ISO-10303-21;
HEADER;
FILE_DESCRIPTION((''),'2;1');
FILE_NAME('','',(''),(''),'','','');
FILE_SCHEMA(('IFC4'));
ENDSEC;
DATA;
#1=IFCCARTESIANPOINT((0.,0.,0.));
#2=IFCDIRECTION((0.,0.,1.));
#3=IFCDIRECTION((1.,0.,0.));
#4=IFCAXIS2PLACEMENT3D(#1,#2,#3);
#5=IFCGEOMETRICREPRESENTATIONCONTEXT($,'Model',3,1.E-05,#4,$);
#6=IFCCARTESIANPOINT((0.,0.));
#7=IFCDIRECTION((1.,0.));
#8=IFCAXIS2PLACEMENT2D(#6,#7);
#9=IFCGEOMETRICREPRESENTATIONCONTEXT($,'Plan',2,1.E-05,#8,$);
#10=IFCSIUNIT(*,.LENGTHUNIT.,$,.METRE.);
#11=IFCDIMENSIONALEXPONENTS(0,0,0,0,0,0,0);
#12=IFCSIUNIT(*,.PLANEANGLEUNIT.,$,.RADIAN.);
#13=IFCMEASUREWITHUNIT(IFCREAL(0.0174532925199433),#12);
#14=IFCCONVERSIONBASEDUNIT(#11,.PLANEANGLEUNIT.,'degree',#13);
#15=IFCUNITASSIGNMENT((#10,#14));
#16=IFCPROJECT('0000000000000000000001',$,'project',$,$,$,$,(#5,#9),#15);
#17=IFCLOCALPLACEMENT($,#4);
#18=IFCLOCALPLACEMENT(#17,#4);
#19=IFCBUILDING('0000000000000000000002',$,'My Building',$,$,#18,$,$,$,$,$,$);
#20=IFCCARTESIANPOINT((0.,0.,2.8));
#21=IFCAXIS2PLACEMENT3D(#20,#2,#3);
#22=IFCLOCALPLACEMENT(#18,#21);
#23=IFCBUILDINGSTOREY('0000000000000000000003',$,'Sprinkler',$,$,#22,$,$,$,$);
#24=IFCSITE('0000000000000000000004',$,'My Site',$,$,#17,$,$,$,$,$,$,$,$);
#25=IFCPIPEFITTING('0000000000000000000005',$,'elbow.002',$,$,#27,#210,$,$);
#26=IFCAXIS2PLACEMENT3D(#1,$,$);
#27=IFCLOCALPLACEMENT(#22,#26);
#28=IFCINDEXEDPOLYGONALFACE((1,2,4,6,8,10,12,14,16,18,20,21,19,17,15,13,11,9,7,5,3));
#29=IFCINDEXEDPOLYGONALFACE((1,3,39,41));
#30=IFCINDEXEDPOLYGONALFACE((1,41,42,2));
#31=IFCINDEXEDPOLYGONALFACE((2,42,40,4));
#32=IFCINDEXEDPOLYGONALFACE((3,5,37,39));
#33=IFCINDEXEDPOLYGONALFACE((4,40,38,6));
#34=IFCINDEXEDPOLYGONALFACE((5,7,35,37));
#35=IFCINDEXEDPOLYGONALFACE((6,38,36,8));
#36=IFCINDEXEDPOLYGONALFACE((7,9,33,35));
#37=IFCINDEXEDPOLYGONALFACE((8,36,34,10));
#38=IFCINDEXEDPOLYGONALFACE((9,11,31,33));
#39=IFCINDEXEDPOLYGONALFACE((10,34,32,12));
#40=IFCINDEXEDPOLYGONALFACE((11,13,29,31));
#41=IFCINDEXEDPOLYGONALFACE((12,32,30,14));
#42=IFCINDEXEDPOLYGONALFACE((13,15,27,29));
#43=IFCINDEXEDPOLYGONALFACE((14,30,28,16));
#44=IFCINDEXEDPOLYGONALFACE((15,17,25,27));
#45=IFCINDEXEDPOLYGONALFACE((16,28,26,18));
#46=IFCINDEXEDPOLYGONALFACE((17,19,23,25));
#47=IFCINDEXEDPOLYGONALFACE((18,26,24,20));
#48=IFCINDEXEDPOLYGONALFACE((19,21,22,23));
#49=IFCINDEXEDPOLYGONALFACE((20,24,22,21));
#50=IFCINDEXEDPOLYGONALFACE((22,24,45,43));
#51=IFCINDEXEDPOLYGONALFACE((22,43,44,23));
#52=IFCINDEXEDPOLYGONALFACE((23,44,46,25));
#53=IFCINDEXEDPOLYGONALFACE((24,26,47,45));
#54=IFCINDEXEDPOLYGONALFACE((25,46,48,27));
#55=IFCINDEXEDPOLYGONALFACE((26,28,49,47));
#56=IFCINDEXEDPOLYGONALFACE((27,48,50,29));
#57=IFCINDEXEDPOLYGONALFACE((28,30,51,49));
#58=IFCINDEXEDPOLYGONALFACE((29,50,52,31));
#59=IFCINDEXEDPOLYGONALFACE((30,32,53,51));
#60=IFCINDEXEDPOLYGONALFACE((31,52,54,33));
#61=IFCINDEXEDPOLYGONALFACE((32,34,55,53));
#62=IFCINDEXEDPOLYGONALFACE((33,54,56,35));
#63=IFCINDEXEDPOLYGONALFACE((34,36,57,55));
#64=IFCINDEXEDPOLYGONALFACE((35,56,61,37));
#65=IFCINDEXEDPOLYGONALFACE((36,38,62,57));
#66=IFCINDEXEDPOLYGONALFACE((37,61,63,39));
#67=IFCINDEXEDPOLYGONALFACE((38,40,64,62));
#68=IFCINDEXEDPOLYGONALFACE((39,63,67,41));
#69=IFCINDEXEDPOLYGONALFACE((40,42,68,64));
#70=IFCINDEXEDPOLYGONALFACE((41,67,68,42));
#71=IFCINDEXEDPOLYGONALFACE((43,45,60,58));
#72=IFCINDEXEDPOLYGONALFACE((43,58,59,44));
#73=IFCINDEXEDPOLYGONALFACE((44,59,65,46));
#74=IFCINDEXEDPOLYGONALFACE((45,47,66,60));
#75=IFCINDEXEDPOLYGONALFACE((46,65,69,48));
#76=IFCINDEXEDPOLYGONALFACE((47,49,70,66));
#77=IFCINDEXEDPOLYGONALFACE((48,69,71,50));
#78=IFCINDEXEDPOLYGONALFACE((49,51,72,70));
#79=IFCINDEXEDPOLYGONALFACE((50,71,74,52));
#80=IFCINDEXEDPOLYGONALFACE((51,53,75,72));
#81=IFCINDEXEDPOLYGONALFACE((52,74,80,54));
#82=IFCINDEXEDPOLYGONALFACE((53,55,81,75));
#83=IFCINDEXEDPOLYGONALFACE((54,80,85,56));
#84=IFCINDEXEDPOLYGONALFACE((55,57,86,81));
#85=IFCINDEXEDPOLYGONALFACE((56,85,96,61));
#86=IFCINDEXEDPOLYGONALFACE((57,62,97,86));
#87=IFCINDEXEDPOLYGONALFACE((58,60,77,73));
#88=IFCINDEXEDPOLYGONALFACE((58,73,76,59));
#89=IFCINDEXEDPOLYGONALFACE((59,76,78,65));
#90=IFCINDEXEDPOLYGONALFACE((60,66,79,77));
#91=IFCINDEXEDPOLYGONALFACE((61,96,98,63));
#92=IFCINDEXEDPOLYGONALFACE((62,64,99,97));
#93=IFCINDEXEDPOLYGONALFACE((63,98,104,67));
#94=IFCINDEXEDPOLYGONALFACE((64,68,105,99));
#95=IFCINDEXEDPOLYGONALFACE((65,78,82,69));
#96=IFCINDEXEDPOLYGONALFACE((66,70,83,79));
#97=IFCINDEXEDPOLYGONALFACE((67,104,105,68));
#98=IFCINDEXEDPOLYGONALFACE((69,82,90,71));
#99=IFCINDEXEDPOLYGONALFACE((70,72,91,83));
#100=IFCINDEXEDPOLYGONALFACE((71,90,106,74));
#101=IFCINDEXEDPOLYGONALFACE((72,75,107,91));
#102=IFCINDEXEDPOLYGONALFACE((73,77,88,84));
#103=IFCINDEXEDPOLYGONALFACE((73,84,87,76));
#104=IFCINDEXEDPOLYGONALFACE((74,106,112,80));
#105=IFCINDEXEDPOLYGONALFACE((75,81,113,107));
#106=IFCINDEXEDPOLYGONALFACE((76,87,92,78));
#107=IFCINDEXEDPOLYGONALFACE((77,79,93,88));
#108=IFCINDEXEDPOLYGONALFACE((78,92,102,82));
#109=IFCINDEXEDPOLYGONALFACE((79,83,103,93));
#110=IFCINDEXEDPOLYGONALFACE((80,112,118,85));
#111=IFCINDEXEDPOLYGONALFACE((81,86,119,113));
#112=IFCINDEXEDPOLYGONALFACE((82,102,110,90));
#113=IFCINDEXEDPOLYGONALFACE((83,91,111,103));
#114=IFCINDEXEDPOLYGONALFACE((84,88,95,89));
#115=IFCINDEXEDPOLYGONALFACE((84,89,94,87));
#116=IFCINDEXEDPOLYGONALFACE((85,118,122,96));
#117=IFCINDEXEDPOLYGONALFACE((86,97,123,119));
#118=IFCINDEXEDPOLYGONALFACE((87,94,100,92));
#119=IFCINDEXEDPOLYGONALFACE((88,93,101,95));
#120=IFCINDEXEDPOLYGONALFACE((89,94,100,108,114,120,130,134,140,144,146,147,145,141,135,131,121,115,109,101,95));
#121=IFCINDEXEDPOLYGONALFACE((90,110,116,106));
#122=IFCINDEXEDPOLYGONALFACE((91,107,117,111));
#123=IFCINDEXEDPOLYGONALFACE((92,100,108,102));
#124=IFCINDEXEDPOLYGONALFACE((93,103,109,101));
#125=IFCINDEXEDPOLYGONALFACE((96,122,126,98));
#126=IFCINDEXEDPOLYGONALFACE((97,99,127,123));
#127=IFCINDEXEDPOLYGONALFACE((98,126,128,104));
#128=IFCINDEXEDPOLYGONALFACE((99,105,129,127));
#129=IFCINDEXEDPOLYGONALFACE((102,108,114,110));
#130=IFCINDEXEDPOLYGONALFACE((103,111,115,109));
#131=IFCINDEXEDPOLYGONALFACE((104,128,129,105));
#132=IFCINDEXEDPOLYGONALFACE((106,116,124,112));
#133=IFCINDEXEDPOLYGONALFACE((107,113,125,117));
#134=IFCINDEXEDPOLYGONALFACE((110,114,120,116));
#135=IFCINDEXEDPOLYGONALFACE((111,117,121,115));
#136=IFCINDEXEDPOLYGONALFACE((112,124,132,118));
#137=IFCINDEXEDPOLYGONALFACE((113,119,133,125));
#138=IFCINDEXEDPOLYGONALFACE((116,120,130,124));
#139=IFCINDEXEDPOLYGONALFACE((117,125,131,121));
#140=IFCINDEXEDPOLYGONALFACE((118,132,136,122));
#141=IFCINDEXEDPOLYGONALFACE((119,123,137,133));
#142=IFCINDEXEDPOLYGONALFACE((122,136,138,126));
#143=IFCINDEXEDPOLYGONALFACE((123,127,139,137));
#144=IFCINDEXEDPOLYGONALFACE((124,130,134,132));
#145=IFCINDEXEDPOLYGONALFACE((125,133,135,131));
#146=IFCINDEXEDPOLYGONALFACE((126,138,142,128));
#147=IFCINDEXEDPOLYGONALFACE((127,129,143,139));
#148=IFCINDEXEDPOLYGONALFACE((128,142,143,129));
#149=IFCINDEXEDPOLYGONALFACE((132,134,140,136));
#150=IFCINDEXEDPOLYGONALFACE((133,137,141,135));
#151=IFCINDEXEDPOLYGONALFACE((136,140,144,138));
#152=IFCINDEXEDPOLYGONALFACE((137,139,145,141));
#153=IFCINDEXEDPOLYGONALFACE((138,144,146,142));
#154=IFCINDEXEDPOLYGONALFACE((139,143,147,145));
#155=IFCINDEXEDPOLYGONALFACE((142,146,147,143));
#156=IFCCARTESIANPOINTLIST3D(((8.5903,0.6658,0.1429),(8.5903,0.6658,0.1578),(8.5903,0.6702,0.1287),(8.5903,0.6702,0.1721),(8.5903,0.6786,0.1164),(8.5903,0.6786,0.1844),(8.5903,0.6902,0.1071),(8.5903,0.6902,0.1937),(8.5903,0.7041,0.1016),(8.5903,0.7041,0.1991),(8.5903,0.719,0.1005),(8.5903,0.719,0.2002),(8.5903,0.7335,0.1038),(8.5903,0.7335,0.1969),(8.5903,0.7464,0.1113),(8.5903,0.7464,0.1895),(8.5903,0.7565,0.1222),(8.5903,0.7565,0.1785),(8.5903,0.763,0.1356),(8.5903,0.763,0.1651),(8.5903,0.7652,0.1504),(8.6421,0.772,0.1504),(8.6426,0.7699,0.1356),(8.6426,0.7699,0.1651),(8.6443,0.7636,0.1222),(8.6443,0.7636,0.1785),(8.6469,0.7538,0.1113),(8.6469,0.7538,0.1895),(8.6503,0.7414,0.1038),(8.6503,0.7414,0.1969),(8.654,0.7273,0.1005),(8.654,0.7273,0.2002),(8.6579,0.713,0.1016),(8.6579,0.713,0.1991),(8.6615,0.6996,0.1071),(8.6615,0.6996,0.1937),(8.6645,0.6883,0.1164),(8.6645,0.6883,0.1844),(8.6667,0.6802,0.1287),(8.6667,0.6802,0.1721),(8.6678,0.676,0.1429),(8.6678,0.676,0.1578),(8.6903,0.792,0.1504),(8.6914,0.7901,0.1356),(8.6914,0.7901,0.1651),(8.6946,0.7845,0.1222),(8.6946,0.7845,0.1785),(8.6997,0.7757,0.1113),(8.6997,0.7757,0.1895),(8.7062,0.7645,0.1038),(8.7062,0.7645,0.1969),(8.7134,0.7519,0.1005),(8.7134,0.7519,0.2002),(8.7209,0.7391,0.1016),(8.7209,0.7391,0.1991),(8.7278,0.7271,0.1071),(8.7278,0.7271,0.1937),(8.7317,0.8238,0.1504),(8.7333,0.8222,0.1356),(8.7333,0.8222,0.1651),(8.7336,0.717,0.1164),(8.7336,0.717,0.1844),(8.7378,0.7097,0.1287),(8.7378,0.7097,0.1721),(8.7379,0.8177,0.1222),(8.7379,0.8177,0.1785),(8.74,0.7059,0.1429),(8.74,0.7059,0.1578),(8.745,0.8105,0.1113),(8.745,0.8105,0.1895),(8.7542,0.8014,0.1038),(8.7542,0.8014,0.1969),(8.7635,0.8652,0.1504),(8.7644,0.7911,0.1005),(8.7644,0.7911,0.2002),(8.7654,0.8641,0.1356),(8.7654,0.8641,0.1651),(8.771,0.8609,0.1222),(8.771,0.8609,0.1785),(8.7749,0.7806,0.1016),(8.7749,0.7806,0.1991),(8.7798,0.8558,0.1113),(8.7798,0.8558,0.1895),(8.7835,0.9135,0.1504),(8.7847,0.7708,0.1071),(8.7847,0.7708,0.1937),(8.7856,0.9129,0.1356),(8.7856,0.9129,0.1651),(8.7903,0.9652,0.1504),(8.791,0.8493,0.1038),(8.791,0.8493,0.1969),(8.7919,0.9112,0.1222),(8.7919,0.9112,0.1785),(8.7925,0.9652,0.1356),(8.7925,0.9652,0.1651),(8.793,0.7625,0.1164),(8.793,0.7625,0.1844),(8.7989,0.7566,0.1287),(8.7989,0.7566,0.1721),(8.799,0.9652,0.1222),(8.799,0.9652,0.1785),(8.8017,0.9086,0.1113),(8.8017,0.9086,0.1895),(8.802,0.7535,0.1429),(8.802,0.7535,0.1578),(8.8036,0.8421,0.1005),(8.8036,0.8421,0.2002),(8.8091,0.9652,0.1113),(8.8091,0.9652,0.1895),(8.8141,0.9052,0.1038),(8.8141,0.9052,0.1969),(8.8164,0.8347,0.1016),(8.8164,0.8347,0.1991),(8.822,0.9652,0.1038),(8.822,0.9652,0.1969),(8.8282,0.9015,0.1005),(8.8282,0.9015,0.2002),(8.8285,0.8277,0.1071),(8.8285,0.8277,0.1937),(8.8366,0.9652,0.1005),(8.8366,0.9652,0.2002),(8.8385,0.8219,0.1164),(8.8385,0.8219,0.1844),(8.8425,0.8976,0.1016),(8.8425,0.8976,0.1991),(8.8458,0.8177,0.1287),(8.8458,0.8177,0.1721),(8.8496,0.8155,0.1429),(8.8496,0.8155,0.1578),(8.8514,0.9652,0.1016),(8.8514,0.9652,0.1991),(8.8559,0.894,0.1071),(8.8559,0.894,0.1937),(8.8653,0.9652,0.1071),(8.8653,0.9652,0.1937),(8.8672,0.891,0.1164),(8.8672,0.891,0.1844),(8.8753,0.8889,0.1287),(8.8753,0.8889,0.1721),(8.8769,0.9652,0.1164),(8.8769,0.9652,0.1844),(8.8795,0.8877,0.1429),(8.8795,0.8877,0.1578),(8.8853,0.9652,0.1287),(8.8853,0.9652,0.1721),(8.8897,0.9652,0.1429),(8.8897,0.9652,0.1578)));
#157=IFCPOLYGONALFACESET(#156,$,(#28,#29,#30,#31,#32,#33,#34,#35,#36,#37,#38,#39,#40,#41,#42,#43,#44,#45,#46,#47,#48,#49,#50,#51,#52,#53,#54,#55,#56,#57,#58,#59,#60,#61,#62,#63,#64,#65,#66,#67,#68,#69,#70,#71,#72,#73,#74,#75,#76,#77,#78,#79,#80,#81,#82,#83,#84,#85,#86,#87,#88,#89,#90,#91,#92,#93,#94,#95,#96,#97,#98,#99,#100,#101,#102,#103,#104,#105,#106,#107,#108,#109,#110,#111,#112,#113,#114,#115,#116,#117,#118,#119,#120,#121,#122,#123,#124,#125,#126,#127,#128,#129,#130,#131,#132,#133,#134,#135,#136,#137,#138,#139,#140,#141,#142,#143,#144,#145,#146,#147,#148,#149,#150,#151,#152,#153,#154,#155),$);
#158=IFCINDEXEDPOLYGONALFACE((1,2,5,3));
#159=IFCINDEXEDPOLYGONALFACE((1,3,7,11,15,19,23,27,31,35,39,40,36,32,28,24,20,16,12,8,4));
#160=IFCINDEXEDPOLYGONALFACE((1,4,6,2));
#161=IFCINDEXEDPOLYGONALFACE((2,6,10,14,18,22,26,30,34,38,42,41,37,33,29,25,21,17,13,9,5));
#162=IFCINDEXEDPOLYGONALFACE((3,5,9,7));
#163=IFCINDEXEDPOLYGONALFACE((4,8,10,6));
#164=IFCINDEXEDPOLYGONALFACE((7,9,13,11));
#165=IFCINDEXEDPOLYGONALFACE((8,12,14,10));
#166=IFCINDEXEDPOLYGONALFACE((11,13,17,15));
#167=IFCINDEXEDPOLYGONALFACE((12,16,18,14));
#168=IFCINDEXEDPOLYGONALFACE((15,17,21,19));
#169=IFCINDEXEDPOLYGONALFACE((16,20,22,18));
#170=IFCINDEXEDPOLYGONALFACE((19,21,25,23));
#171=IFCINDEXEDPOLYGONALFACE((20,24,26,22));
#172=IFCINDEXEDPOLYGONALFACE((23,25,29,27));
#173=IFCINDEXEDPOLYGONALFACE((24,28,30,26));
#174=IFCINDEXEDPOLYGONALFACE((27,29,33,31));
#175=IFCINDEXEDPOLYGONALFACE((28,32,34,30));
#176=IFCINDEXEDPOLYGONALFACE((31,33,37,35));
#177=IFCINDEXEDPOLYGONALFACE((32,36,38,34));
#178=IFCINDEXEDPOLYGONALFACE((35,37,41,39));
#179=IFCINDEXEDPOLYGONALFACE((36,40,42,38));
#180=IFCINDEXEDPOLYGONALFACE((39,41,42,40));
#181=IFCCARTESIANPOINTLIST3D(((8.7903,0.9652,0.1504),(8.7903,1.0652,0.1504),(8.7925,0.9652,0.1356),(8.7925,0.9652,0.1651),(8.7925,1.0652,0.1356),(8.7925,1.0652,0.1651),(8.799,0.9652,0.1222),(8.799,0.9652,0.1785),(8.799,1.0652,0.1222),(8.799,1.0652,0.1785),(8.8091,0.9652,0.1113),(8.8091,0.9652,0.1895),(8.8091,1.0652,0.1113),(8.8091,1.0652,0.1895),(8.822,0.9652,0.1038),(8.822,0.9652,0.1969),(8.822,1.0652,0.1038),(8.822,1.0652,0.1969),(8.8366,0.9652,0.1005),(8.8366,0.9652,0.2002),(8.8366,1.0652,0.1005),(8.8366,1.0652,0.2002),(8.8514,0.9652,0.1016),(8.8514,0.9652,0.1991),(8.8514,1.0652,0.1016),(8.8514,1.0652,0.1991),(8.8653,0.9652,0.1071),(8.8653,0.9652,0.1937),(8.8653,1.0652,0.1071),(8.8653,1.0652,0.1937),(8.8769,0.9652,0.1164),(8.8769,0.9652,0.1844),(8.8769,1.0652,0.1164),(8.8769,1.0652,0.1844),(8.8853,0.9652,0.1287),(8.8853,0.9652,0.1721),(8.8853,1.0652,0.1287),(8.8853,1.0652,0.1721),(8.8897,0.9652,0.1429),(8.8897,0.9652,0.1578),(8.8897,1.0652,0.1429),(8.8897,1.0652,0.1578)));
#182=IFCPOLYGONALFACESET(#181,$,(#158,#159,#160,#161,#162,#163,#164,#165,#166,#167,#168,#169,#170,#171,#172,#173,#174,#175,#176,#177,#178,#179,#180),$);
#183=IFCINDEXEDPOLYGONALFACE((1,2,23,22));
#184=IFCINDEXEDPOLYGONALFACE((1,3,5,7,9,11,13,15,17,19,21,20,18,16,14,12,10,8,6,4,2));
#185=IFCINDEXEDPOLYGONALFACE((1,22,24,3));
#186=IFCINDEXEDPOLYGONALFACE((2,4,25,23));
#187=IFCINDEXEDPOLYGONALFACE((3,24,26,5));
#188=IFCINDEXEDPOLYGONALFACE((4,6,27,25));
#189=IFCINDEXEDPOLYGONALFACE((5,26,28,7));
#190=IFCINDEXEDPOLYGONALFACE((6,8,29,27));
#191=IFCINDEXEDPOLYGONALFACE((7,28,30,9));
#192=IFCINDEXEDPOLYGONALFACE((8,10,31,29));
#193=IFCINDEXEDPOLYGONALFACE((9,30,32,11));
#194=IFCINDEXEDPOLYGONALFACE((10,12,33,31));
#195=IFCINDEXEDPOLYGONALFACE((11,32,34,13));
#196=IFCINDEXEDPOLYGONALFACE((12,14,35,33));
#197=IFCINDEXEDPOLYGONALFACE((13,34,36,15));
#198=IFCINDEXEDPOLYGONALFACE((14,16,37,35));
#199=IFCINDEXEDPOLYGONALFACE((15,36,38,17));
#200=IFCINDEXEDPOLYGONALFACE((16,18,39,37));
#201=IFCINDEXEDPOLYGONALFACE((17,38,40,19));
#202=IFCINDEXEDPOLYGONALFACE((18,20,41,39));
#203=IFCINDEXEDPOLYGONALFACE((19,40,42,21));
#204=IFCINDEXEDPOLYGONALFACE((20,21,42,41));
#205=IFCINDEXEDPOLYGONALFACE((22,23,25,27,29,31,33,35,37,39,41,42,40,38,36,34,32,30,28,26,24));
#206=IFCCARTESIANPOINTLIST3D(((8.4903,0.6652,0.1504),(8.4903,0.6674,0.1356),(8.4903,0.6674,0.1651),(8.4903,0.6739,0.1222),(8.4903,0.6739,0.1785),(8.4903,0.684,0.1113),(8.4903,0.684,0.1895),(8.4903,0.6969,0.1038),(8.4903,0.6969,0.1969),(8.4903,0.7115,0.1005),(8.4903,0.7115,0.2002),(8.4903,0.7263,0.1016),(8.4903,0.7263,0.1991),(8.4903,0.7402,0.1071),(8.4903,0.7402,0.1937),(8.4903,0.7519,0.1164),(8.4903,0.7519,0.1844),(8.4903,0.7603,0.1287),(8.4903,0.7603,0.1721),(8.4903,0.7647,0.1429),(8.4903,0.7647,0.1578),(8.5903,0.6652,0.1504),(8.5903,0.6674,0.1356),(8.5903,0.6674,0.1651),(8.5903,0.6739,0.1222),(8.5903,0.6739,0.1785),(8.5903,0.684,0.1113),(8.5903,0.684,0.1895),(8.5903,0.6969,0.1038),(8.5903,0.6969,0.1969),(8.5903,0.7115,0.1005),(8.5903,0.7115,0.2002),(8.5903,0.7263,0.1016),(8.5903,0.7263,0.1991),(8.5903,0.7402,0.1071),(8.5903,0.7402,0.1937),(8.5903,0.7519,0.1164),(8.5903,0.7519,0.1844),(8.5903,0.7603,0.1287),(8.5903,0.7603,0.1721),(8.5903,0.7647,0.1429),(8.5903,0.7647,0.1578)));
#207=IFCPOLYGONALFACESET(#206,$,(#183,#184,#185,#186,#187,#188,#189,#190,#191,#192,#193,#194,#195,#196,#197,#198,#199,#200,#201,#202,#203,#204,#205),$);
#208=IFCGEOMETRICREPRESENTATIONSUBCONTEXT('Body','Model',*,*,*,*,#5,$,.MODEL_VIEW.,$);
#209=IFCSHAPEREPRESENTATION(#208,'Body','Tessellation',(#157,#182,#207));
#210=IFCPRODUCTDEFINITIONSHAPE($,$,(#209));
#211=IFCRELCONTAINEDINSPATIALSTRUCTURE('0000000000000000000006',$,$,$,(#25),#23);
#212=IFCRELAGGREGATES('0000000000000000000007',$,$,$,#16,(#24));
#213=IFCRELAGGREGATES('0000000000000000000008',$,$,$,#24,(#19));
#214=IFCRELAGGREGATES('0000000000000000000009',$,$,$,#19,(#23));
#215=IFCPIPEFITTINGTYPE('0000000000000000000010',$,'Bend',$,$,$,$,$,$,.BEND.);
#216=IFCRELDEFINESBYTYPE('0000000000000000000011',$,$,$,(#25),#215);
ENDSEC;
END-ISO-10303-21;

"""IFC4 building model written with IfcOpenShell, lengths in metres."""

from ifc_helpers import new_model, entity, si_unit, converted_unit, frame, origin_with_axes, origin_2d_with_axis, place, context, subcontext, project, spatial, circle, extrude, source, transform, mapped, type_object, type_shapes, element, save


model = new_model("IFC4")

# Units and contexts
model_context = context("Model", 3, precision=1e-05, world=origin_with_axes())
plan_context = context("Plan", 2, precision=1e-05, world=origin_2d_with_axis())
body_context = subcontext(model_context, "Body", "Model", "MODEL_VIEW")
ifc_project = project(units=[si_unit("LENGTHUNIT", "METRE"), converted_unit("PLANEANGLEUNIT", "degree", entity("IfcReal", 0.0174532925199433), si_unit("PLANEANGLEUNIT", "RADIAN"), dimensions=[0, 0, 0, 0, 0, 0, 0])], contexts=[model_context, plan_context])

# Site, building, storey
site_placement = place(None, origin_with_axes())
site = spatial("IfcSite", under=ifc_project, at=site_placement, Name="My Site")
building_placement = place(site_placement, origin_with_axes())
building = spatial("IfcBuilding", under=site, at=building_placement, Name="My Building")
storey_placement = place(building_placement, frame((0.0, 0.0, 2.8), z_axis=(0.0, 0.0, 1.0), x_axis=(1.0, 0.0, 0.0)))
storey = spatial("IfcBuildingStorey", under=building, at=storey_placement, Name="Sprinkler")

# Pipe fitting
pipe_fitting_type_1 = type_object("IfcPipeFittingType", Name="Bend", PredefinedType="BEND")
shared_shape_1 = source(origin_with_axes(), body_context, "Body", "SolidModel", [
    entity("IfcSweptDiskSolid", entity("IfcIndexedPolyCurve", entity("IfcCartesianPointList3D", [[0.0, 0.0, 0.1], [0.0732, 0.0, 0.2768], [0.25, 0.0, 0.35]]), [entity("IfcArcIndex", [1, 2, 3])]), 0.05),
    extrude(circle(Radius=0.05), origin_with_axes(), (0.0, 0.0, 1.0), 0.1),
    extrude(circle(Radius=0.05), frame((0.25, 0.0, 0.35), z_axis=(1.0, 0.0, 0.000001), x_axis=(-0.000001, 0.0, 1.0)), (0.0, 0.0, 1.0), 0.1),
])
type_shapes(pipe_fitting_type_1, [shared_shape_1])
for number, where, z_axis, x_axis, name in (
    (1, (8.8403, 1.0652, 0.1504), (0.000001, -1.0, 0.0), (-1.0, -0.000001, 0.0), "elbow.002"),
):
    element("IfcPipeFitting", number, at=place(storey_placement, frame(where, z_axis=z_axis, x_axis=x_axis)), inside=storey, type_object=pipe_fitting_type_1, Name=name, context=body_context, shape_type="MappedRepresentation", body=[
        mapped(shared_shape_1, transform((0.0, 0.0, 0.0), x_axis=(1.0, 0.0, 0.0), y_axis=(0.0, 1.0, 0.0), z_axis=(0.0, 0.0, 1.0), scale=1.0)),
    ])

save(model, "model.ifc")
